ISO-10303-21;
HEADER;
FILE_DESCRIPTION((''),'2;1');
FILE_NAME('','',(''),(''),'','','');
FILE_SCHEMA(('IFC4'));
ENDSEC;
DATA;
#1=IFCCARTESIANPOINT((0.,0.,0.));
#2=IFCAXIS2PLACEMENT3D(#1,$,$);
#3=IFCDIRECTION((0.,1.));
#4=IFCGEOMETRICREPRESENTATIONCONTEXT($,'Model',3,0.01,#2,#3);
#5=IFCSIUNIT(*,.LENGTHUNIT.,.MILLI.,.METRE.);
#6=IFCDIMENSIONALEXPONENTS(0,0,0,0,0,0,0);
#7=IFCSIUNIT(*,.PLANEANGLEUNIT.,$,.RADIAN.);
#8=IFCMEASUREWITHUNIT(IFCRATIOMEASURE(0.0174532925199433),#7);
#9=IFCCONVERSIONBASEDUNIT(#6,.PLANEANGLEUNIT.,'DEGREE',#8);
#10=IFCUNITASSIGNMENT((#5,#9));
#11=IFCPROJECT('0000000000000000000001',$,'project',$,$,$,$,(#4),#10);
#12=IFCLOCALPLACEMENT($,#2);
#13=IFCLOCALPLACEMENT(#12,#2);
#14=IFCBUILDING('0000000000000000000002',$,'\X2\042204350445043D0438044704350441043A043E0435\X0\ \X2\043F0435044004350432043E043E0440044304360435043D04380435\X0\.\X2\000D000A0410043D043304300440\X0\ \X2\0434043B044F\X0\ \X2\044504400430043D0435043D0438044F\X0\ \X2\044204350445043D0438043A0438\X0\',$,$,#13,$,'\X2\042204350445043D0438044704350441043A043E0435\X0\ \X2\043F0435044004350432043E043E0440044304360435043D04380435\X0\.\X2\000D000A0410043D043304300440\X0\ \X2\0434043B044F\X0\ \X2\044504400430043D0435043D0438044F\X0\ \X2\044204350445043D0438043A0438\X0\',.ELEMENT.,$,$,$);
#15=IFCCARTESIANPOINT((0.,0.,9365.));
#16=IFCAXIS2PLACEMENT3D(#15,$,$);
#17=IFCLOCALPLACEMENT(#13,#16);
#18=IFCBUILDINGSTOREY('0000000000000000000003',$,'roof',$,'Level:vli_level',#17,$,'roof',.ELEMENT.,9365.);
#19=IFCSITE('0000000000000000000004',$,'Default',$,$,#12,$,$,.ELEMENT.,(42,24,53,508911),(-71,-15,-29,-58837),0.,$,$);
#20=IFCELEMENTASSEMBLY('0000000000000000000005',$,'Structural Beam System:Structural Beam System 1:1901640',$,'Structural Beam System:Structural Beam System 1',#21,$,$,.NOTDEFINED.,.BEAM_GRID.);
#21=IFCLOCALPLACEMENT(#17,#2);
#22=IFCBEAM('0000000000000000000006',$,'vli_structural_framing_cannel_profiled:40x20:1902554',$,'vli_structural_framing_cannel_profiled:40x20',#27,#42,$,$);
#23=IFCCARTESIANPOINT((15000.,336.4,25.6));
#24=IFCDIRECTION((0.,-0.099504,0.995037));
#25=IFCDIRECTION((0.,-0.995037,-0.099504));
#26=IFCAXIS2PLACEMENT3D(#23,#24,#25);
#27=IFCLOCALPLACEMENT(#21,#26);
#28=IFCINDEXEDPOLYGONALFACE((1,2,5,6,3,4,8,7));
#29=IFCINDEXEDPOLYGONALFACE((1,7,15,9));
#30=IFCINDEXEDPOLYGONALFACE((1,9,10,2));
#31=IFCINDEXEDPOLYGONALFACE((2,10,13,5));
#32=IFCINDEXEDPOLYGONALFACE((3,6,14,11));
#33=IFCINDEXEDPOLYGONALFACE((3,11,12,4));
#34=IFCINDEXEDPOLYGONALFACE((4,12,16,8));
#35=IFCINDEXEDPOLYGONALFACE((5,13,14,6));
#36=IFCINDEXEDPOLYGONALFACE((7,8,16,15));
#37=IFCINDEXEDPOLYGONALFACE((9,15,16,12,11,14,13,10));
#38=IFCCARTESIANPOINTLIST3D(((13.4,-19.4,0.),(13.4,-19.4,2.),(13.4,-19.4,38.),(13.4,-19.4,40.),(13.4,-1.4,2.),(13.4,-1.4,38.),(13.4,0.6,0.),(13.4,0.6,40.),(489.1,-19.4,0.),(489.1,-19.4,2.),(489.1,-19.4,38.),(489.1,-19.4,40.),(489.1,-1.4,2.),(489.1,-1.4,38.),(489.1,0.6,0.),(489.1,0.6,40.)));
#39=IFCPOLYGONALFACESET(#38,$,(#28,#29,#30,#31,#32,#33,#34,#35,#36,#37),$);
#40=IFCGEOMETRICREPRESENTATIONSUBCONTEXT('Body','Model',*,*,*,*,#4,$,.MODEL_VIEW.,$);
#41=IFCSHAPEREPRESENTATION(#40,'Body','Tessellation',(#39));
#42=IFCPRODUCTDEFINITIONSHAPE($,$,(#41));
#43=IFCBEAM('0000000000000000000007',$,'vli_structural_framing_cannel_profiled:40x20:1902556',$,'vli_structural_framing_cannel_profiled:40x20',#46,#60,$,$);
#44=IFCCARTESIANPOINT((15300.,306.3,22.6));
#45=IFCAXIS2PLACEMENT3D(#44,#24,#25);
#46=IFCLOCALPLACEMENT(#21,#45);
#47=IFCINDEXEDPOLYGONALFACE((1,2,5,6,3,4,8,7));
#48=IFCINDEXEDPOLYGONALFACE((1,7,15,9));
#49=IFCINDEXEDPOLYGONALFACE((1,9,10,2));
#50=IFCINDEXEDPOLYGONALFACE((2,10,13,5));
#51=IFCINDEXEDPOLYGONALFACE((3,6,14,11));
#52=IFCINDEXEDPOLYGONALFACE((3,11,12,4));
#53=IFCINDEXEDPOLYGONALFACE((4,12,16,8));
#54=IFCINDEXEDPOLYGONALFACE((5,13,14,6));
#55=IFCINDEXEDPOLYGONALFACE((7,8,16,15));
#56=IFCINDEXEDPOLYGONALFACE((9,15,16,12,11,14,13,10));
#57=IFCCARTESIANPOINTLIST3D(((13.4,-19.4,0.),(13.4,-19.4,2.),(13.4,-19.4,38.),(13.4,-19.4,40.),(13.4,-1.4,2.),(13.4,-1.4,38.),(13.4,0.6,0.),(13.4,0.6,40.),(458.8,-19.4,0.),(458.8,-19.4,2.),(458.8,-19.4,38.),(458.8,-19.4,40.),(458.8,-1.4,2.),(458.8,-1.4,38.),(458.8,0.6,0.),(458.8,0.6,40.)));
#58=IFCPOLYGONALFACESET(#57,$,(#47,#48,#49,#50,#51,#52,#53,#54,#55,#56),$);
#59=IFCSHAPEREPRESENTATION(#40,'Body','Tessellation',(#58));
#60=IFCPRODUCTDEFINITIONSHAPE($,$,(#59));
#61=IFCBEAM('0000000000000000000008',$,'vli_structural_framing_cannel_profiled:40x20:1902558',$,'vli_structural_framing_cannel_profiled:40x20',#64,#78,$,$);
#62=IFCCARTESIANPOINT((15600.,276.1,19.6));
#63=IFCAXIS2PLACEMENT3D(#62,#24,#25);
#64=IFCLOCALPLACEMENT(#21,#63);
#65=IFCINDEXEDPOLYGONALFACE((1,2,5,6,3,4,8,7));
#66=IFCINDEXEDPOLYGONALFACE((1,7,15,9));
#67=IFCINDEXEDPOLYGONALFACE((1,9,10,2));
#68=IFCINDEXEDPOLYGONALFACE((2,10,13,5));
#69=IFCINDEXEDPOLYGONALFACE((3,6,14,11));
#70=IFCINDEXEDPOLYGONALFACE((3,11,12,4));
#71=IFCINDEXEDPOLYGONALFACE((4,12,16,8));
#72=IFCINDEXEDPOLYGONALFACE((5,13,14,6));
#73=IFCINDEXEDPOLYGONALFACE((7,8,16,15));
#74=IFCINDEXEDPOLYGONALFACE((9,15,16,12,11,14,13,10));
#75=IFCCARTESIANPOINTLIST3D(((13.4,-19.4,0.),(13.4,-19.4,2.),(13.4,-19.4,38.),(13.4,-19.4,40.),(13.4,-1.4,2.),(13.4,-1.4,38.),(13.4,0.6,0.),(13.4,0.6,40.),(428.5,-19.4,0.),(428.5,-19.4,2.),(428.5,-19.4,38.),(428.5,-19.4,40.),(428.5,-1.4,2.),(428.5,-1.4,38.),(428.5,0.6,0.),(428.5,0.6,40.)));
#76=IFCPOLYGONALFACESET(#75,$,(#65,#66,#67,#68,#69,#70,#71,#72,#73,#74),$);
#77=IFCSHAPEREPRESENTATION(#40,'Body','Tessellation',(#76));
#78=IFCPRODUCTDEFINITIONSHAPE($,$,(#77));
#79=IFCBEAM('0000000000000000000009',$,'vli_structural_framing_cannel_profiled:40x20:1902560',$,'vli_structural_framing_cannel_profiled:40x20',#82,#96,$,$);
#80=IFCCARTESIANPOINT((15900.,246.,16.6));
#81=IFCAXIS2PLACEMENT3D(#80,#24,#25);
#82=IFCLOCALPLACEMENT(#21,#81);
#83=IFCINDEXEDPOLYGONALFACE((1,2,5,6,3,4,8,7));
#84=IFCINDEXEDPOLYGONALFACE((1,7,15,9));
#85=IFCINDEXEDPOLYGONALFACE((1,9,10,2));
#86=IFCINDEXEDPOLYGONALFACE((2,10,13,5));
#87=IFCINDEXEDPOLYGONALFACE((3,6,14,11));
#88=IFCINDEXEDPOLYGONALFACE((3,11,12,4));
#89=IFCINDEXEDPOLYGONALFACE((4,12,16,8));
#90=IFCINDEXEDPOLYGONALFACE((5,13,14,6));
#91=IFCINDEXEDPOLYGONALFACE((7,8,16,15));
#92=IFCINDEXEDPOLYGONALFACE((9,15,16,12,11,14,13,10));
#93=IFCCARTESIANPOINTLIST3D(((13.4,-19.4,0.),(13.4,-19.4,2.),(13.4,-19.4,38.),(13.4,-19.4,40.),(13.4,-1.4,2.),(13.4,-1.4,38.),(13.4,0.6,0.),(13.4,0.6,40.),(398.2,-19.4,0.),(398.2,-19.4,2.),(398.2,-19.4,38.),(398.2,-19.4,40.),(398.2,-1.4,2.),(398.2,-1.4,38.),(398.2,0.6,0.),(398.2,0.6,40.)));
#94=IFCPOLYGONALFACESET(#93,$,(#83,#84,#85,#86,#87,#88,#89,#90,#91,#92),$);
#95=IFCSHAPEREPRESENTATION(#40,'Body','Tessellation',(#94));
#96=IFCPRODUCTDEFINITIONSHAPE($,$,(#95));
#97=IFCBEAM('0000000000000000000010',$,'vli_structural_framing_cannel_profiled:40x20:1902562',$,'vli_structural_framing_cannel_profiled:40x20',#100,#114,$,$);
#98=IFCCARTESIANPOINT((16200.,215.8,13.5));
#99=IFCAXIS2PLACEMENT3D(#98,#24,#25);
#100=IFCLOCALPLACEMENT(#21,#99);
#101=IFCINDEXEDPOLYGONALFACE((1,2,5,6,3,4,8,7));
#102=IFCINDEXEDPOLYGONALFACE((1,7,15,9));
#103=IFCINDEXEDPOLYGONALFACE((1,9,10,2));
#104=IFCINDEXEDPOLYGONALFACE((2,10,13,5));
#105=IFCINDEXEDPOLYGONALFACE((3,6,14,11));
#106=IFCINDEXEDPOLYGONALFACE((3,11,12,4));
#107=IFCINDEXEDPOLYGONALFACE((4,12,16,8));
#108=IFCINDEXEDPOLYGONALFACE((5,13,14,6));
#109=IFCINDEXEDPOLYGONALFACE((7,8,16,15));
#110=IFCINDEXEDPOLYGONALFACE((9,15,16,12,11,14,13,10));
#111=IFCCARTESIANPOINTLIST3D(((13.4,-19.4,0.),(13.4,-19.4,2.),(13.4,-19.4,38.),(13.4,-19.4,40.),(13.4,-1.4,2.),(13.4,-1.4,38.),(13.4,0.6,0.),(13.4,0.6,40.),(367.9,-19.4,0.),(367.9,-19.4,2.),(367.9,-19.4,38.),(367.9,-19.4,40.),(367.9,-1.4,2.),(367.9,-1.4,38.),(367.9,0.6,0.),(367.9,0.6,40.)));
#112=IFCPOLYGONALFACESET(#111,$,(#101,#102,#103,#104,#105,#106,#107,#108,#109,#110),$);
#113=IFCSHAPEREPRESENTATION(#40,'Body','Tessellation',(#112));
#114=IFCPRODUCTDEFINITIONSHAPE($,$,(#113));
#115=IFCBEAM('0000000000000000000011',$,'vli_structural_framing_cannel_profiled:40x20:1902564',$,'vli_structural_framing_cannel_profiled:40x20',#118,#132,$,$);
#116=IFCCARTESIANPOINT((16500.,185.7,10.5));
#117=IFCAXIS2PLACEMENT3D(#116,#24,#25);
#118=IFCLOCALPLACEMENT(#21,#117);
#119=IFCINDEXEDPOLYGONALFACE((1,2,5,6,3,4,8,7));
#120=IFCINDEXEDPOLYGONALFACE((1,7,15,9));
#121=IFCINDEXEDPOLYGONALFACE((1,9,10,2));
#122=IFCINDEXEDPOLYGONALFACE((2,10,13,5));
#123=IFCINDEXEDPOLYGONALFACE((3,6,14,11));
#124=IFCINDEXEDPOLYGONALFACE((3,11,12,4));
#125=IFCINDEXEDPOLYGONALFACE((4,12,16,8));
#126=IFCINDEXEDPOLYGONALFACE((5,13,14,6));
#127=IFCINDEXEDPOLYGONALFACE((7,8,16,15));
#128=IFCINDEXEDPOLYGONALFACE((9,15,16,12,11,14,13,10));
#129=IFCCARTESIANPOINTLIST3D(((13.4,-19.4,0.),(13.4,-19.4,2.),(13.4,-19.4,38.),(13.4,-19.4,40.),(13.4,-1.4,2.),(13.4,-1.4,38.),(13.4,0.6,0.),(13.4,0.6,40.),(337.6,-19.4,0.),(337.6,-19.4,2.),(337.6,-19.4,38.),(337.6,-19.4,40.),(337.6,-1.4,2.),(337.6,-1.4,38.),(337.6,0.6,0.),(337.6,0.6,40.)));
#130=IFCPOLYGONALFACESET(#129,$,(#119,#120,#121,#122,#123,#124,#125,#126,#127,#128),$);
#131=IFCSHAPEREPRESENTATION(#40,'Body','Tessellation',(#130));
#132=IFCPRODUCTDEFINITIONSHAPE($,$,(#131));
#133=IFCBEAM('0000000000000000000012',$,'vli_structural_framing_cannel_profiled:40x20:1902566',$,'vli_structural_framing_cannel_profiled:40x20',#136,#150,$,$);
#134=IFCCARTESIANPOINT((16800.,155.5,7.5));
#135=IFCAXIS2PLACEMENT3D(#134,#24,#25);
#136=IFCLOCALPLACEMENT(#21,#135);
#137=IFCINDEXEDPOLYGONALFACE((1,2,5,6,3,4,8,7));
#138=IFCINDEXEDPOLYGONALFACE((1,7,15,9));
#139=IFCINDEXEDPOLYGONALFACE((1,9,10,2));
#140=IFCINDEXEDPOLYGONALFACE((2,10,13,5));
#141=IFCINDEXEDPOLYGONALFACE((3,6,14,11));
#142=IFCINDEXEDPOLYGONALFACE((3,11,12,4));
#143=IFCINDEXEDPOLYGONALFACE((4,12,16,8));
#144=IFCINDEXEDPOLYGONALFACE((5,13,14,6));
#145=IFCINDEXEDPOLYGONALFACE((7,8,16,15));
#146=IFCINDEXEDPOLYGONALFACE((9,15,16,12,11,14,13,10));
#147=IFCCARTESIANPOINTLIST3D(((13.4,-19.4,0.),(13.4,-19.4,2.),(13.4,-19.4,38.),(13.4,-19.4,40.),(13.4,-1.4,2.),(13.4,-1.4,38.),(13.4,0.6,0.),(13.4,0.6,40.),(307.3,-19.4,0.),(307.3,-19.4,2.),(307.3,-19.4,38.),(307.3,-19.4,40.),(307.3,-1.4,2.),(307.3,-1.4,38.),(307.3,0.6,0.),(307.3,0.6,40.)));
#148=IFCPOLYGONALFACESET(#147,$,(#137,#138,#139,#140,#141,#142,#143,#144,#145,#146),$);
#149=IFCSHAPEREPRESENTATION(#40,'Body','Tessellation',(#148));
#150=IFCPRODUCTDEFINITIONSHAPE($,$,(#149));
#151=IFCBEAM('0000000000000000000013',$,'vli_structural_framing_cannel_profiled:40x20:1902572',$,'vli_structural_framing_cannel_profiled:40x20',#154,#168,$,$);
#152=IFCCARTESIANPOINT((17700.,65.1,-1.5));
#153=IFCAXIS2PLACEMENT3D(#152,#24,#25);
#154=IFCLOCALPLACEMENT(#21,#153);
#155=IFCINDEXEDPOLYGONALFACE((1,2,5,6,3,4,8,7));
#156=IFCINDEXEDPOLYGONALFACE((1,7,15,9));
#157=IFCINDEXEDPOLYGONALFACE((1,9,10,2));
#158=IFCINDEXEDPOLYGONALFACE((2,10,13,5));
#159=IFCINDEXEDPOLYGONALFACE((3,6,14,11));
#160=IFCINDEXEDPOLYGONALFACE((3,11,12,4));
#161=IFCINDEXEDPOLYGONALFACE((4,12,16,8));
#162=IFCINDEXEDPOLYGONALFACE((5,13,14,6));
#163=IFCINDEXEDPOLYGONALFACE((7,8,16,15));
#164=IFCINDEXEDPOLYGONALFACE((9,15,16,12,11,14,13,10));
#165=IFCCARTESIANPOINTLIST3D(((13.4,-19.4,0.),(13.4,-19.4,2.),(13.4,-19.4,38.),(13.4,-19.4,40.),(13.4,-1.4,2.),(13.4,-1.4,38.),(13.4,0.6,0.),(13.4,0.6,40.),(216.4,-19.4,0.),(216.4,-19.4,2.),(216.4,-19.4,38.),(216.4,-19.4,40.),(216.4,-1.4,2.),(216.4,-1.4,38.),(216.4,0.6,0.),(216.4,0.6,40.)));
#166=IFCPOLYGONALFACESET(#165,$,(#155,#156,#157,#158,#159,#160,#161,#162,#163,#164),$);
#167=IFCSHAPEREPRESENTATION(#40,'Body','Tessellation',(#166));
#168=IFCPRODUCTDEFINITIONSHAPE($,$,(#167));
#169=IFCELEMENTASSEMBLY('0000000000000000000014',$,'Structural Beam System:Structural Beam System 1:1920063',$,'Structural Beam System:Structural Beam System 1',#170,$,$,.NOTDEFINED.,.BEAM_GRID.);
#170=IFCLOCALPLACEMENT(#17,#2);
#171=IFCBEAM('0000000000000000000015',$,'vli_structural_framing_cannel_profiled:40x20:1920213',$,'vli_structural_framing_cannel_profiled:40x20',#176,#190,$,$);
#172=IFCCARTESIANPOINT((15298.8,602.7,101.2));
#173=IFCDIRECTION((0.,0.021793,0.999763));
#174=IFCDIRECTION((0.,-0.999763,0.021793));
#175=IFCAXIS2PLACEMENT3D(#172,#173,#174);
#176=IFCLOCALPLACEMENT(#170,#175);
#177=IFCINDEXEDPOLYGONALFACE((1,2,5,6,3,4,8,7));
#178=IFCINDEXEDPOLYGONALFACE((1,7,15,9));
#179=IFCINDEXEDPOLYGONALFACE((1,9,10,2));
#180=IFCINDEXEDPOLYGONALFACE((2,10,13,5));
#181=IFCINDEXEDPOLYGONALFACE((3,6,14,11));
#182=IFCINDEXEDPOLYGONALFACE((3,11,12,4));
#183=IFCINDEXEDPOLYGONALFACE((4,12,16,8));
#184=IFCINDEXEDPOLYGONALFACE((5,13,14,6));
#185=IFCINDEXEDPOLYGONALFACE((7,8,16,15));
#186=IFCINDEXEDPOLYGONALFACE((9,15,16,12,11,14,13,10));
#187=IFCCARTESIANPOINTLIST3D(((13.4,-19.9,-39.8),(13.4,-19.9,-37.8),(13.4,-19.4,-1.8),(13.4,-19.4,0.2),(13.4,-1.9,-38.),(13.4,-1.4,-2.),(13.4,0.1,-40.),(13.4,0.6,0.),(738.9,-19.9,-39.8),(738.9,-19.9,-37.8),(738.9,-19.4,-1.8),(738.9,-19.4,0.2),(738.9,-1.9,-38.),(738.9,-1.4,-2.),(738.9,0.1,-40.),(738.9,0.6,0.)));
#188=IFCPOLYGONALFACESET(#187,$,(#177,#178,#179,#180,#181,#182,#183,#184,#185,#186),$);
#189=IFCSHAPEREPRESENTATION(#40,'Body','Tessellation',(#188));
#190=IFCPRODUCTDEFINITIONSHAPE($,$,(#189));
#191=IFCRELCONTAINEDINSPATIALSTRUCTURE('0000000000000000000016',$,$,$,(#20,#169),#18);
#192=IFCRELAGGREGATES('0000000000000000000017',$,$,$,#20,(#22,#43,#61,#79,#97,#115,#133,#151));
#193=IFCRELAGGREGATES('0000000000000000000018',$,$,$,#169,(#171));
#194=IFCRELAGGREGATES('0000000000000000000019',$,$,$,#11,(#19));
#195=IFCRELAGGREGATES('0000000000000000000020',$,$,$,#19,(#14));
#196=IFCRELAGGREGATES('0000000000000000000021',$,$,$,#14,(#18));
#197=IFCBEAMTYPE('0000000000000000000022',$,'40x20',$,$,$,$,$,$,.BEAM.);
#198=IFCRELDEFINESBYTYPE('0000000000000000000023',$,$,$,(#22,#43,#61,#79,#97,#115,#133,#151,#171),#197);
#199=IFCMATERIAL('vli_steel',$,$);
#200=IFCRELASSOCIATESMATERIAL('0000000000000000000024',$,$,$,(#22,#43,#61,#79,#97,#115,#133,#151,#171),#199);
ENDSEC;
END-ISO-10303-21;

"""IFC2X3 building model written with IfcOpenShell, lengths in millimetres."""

from ifc_helpers import new_model, entity, si_unit, converted_unit, direction, frame, origin, place, context, subcontext, project, spatial, polyline, outline, extrude, material, type_object, element, aggregate, save


model = new_model("IFC2X3")

# Units and contexts
model_context = context("Model", 3, precision=0.01, world=origin(), true_north=direction((0.0, 1.0)))
body_context = subcontext(model_context, "Body", "Model", "MODEL_VIEW")
ifc_project = project(units=[si_unit("LENGTHUNIT", "METRE", prefix="MILLI"), converted_unit("PLANEANGLEUNIT", "DEGREE", entity("IfcRatioMeasure", 0.0174532925199433), si_unit("PLANEANGLEUNIT", "RADIAN"), dimensions=[0, 0, 0, 0, 0, 0, 0])], contexts=[model_context])

# Site, building, storey
site_placement = place(None, origin())
site = spatial("IfcSite", under=ifc_project, at=site_placement, Name="Default", CompositionType="ELEMENT", RefLatitude=(42, 24, 53, 508911), RefLongitude=(-71, -15, -29, -58837), RefElevation=0.0)
building_placement = place(site_placement, origin())
building = spatial("IfcBuilding", under=site, at=building_placement, Name="Техническое перевооружение.\r\nАнгар для хранения техники", LongName="Техническое перевооружение.\r\nАнгар для хранения техники", CompositionType="ELEMENT")
storey_placement = place(building_placement, frame((0.0, 0.0, 9365.0)))
storey = spatial("IfcBuildingStorey", under=building, at=storey_placement, Name="roof", ObjectType="Level:vli_level", LongName="roof", CompositionType="ELEMENT", Elevation=9365.0)

# Element assemblies, beams
assembly_1_placement = place(storey_placement, origin())
assembly_1 = element("IfcElementAssembly", 1, at=assembly_1_placement, inside=storey, Name="Structural Beam System:Structural Beam System 1:1901640", ObjectType="Structural Beam System:Structural Beam System 1", AssemblyPlace="NOTDEFINED", PredefinedType="BEAM_GRID")
ifc_material = material(Name="vli_steel")
beam_type = type_object("IfcBeamType", Name="40x20", PredefinedType="BEAM")
beam_1_placement = place(assembly_1_placement, frame((15000.0, 336.4, 25.6), z_axis=(0.0, -0.099504, 0.995037), x_axis=(0.0, -0.995037, -0.099504)))
beam_1 = element("IfcBeam", 2, at=beam_1_placement, type_object=beam_type, material=ifc_material, Name="vli_structural_framing_cannel_profiled:40x20:1902554", ObjectType="vli_structural_framing_cannel_profiled:40x20", context=body_context, shape_type="SweptSolid", body=[
    extrude(outline(polyline([(-20.0, -9.5), (-18.0, -9.5), (-18.0, 8.5), (18.0, 8.5), (18.0, -9.5), (20.0, -9.5), (20.0, 10.5), (-20.0, 10.5), (-20.0, -9.5)])), frame((13.4, -9.9, 20.0), z_axis=(1.0, 0.0, 0.0), x_axis=(0.0, 0.0, -1.0)), (0.0, 0.0, 1.0), 475.7),
])
beam_2_placement = place(assembly_1_placement, frame((15300.0, 306.3, 22.6), z_axis=(0.0, -0.099504, 0.995037), x_axis=(0.0, -0.995037, -0.099504)))
beam_2 = element("IfcBeam", 3, at=beam_2_placement, type_object=beam_type, material=ifc_material, Name="vli_structural_framing_cannel_profiled:40x20:1902556", ObjectType="vli_structural_framing_cannel_profiled:40x20", context=body_context, shape_type="SweptSolid", body=[
    extrude(outline(polyline([(-20.0, -9.5), (-18.0, -9.5), (-18.0, 8.5), (18.0, 8.5), (18.0, -9.5), (20.0, -9.5), (20.0, 10.5), (-20.0, 10.5), (-20.0, -9.5)])), frame((13.4, -9.9, 20.0), z_axis=(1.0, 0.0, 0.0), x_axis=(0.0, 0.0, -1.0)), (0.0, 0.0, 1.0), 445.4),
])
beam_3_placement = place(assembly_1_placement, frame((15600.0, 276.1, 19.6), z_axis=(0.0, -0.099504, 0.995037), x_axis=(0.0, -0.995037, -0.099504)))
beam_3 = element("IfcBeam", 4, at=beam_3_placement, type_object=beam_type, material=ifc_material, Name="vli_structural_framing_cannel_profiled:40x20:1902558", ObjectType="vli_structural_framing_cannel_profiled:40x20", context=body_context, shape_type="SweptSolid", body=[
    extrude(outline(polyline([(-20.0, -9.5), (-18.0, -9.5), (-18.0, 8.5), (18.0, 8.5), (18.0, -9.5), (20.0, -9.5), (20.0, 10.5), (-20.0, 10.5), (-20.0, -9.5)])), frame((13.4, -9.9, 20.0), z_axis=(1.0, 0.0, 0.0), x_axis=(0.0, 0.0, -1.0)), (0.0, 0.0, 1.0), 415.1),
])
beam_4_placement = place(assembly_1_placement, frame((15900.0, 246.0, 16.6), z_axis=(0.0, -0.099504, 0.995037), x_axis=(0.0, -0.995037, -0.099504)))
beam_4 = element("IfcBeam", 5, at=beam_4_placement, type_object=beam_type, material=ifc_material, Name="vli_structural_framing_cannel_profiled:40x20:1902560", ObjectType="vli_structural_framing_cannel_profiled:40x20", context=body_context, shape_type="SweptSolid", body=[
    extrude(outline(polyline([(-20.0, -9.5), (-18.0, -9.5), (-18.0, 8.5), (18.0, 8.5), (18.0, -9.5), (20.0, -9.5), (20.0, 10.5), (-20.0, 10.5), (-20.0, -9.5)])), frame((13.4, -9.9, 20.0), z_axis=(1.0, 0.0, 0.0), x_axis=(0.0, 0.0, -1.0)), (0.0, 0.0, 1.0), 384.8),
])
beam_5_placement = place(assembly_1_placement, frame((16200.0, 215.8, 13.5), z_axis=(0.0, -0.099504, 0.995037), x_axis=(0.0, -0.995037, -0.099504)))
beam_5 = element("IfcBeam", 6, at=beam_5_placement, type_object=beam_type, material=ifc_material, Name="vli_structural_framing_cannel_profiled:40x20:1902562", ObjectType="vli_structural_framing_cannel_profiled:40x20", context=body_context, shape_type="SweptSolid", body=[
    extrude(outline(polyline([(-20.0, -9.5), (-18.0, -9.5), (-18.0, 8.5), (18.0, 8.5), (18.0, -9.5), (20.0, -9.5), (20.0, 10.5), (-20.0, 10.5), (-20.0, -9.5)])), frame((13.4, -9.9, 20.0), z_axis=(1.0, 0.0, 0.0), x_axis=(0.0, 0.0, -1.0)), (0.0, 0.0, 1.0), 354.5),
])
beam_6_placement = place(assembly_1_placement, frame((16500.0, 185.7, 10.5), z_axis=(0.0, -0.099504, 0.995037), x_axis=(0.0, -0.995037, -0.099504)))
beam_6 = element("IfcBeam", 7, at=beam_6_placement, type_object=beam_type, material=ifc_material, Name="vli_structural_framing_cannel_profiled:40x20:1902564", ObjectType="vli_structural_framing_cannel_profiled:40x20", context=body_context, shape_type="SweptSolid", body=[
    extrude(outline(polyline([(-20.0, -9.5), (-18.0, -9.5), (-18.0, 8.5), (18.0, 8.5), (18.0, -9.5), (20.0, -9.5), (20.0, 10.5), (-20.0, 10.5), (-20.0, -9.5)])), frame((13.4, -9.9, 20.0), z_axis=(1.0, 0.0, 0.0), x_axis=(0.0, 0.0, -1.0)), (0.0, 0.0, 1.0), 324.2),
])
beam_7_placement = place(assembly_1_placement, frame((16800.0, 155.5, 7.5), z_axis=(0.0, -0.099504, 0.995037), x_axis=(0.0, -0.995037, -0.099504)))
beam_7 = element("IfcBeam", 8, at=beam_7_placement, type_object=beam_type, material=ifc_material, Name="vli_structural_framing_cannel_profiled:40x20:1902566", ObjectType="vli_structural_framing_cannel_profiled:40x20", context=body_context, shape_type="SweptSolid", body=[
    extrude(outline(polyline([(-20.0, -9.5), (-18.0, -9.5), (-18.0, 8.5), (18.0, 8.5), (18.0, -9.5), (20.0, -9.5), (20.0, 10.5), (-20.0, 10.5), (-20.0, -9.5)])), frame((13.4, -9.9, 20.0), z_axis=(1.0, 0.0, 0.0), x_axis=(0.0, 0.0, -1.0)), (0.0, 0.0, 1.0), 293.9),
])
beam_8_placement = place(assembly_1_placement, frame((17700.0, 65.1, -1.5), z_axis=(0.0, -0.099504, 0.995037), x_axis=(0.0, -0.995037, -0.099504)))
beam_8 = element("IfcBeam", 9, at=beam_8_placement, type_object=beam_type, material=ifc_material, Name="vli_structural_framing_cannel_profiled:40x20:1902572", ObjectType="vli_structural_framing_cannel_profiled:40x20", context=body_context, shape_type="SweptSolid", body=[
    extrude(outline(polyline([(-20.0, -9.5), (-18.0, -9.5), (-18.0, 8.5), (18.0, 8.5), (18.0, -9.5), (20.0, -9.5), (20.0, 10.5), (-20.0, 10.5), (-20.0, -9.5)])), frame((13.4, -9.9, 20.0), z_axis=(1.0, 0.0, 0.0), x_axis=(0.0, 0.0, -1.0)), (0.0, 0.0, 1.0), 203.0),
])
aggregate(assembly_1, [beam_1, beam_2, beam_3, beam_4, beam_5, beam_6, beam_7, beam_8])
assembly_2_placement = place(storey_placement, origin())
assembly_2 = element("IfcElementAssembly", 10, at=assembly_2_placement, inside=storey, Name="Structural Beam System:Structural Beam System 1:1920063", ObjectType="Structural Beam System:Structural Beam System 1", AssemblyPlace="NOTDEFINED", PredefinedType="BEAM_GRID")
beam_9_placement = place(assembly_2_placement, frame((15298.8, 602.7, 101.2), z_axis=(0.0, 0.021793, 0.999763), x_axis=(0.0, -0.999763, 0.021793)))
beam_9 = element("IfcBeam", 11, at=beam_9_placement, type_object=beam_type, material=ifc_material, Name="vli_structural_framing_cannel_profiled:40x20:1920213", ObjectType="vli_structural_framing_cannel_profiled:40x20", context=body_context, shape_type="SweptSolid", body=[
    extrude(outline(polyline([(-10.5, -20.0), (9.5, -20.0), (9.5, -18.0), (-8.5, -18.0), (-8.5, 18.0), (9.5, 18.0), (9.5, 20.0), (-10.5, 20.0), (-10.5, -20.0)])), frame((13.4, -10.1, -19.9), z_axis=(1.0, 0.0, 0.0), x_axis=(0.0, -0.999925, 0.012237)), (0.0, 0.0, 1.0), 725.6),
])
aggregate(assembly_2, [beam_9])

save(model, "model.ifc")
